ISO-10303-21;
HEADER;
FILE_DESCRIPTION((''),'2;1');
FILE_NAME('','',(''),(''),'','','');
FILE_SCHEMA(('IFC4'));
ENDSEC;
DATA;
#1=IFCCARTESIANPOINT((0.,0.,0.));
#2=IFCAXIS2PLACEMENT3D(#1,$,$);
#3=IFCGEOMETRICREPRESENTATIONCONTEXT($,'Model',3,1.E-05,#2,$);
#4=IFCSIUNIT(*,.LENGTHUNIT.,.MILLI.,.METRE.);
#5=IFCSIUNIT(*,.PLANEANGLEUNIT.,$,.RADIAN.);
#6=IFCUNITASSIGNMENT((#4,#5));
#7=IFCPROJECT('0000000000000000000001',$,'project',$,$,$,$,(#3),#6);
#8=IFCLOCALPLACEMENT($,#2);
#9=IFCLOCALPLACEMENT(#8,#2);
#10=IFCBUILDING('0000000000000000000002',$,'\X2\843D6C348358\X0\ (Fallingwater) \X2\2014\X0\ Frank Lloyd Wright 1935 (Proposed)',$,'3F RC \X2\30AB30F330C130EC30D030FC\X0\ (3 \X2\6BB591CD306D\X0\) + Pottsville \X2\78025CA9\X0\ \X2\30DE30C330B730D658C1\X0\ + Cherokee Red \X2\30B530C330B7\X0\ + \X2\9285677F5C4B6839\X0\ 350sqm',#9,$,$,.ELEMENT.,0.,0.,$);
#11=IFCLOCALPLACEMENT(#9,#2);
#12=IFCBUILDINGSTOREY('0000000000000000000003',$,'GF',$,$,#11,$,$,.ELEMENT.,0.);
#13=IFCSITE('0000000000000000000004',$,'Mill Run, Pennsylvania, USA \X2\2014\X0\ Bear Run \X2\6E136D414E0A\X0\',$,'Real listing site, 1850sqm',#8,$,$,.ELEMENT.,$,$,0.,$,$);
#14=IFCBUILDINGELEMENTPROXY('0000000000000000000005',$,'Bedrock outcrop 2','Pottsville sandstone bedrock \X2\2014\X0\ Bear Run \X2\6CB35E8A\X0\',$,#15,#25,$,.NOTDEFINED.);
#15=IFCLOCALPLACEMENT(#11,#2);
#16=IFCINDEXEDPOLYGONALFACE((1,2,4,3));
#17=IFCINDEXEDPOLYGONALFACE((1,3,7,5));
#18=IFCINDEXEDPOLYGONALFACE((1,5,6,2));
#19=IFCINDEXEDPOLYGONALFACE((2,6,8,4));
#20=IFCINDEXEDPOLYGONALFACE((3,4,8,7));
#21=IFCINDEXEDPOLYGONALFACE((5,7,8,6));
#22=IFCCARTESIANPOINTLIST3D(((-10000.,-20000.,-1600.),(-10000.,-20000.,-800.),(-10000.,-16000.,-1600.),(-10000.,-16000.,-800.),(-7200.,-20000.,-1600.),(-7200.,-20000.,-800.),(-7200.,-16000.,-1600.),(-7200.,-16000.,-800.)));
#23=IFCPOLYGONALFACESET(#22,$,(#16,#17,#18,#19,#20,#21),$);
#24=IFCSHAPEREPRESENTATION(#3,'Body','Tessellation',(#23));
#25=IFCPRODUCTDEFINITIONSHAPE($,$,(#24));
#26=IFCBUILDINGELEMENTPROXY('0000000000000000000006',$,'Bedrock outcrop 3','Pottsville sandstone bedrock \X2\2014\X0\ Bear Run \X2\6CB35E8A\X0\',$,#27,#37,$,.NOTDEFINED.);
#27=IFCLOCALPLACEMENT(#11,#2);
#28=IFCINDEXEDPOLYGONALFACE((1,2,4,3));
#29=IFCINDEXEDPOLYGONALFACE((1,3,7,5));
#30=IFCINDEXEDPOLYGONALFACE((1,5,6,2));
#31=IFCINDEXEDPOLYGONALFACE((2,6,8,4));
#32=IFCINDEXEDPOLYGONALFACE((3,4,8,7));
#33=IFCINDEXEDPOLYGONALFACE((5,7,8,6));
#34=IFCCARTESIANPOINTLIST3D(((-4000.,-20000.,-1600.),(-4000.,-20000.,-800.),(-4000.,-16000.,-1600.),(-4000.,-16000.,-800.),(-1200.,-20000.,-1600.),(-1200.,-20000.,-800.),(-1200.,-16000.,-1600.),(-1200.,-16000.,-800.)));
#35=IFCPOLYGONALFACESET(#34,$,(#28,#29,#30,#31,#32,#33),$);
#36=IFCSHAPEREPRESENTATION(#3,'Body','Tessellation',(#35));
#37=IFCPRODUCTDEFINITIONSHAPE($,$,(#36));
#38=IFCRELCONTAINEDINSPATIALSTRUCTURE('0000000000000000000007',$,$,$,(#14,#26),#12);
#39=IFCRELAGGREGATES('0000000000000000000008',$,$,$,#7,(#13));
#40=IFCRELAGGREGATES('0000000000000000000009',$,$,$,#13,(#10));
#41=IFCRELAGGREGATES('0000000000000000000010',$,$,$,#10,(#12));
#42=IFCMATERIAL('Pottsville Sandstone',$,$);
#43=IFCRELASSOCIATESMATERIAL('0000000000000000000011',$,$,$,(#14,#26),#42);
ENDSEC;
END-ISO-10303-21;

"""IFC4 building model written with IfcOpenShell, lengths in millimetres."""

from ifc_helpers import new_model, si_unit, frame, frame_2d, origin, place, context, project, spatial, rectangle, extrude, material, element, save


model = new_model("IFC4")

# Units and contexts
model_context = context("Model", 3, precision=1e-05, world=origin())
ifc_project = project(units=[si_unit("LENGTHUNIT", "METRE", prefix="MILLI"), si_unit("PLANEANGLEUNIT", "RADIAN")], contexts=[model_context])

# Site, building, storey
site_placement = place(None, origin())
site = spatial("IfcSite", under=ifc_project, at=site_placement, Name="Mill Run, Pennsylvania, USA — Bear Run 渓流上", ObjectType="Real listing site, 1850sqm", CompositionType="ELEMENT", RefElevation=0.0)
building_placement = place(site_placement, origin())
building = spatial("IfcBuilding", under=site, at=building_placement, Name="落水荘 (Fallingwater) — Frank Lloyd Wright 1935 (Proposed)", ObjectType="3F RC カンチレバー (3 段重ね) + Pottsville 砂岩 マッシブ壁 + Cherokee Red サッシ + 銅板屋根 350sqm", CompositionType="ELEMENT", ElevationOfRefHeight=0.0, ElevationOfTerrain=0.0)
storey_placement = place(building_placement, origin())
storey = spatial("IfcBuildingStorey", under=building, at=storey_placement, Name="GF", CompositionType="ELEMENT", Elevation=0.0)

# Building element proxies
ifc_material_1 = material(Name="Pottsville Sandstone")
proxy_1_placement = place(storey_placement, frame((-5000.0, -10000.0, -800.0)))
element("IfcBuildingElementProxy", 1, at=proxy_1_placement, inside=storey, material=ifc_material_1, Name="Bedrock outcrop 2", Description="Pottsville sandstone bedrock — Bear Run 河床", PredefinedType="NOTDEFINED", context=model_context, shape_type="SweptSolid", body=[
    extrude(rectangle(XDim=2800.0, YDim=4000.0, at=frame_2d((1400.0, 2000.0))), frame((-5000.0, -10000.0, -800.0)), (0.0, 0.0, 1.0), 800.0),
])
proxy_2_placement = place(storey_placement, frame((-2000.0, -10000.0, -800.0)))
element("IfcBuildingElementProxy", 2, at=proxy_2_placement, inside=storey, material=ifc_material_1, Name="Bedrock outcrop 3", Description="Pottsville sandstone bedrock — Bear Run 河床", PredefinedType="NOTDEFINED", context=model_context, shape_type="SweptSolid", body=[
    extrude(rectangle(XDim=2800.0, YDim=4000.0, at=frame_2d((1400.0, 2000.0))), frame((-2000.0, -10000.0, -800.0)), (0.0, 0.0, 1.0), 800.0),
])

save(model, "model.ifc")
